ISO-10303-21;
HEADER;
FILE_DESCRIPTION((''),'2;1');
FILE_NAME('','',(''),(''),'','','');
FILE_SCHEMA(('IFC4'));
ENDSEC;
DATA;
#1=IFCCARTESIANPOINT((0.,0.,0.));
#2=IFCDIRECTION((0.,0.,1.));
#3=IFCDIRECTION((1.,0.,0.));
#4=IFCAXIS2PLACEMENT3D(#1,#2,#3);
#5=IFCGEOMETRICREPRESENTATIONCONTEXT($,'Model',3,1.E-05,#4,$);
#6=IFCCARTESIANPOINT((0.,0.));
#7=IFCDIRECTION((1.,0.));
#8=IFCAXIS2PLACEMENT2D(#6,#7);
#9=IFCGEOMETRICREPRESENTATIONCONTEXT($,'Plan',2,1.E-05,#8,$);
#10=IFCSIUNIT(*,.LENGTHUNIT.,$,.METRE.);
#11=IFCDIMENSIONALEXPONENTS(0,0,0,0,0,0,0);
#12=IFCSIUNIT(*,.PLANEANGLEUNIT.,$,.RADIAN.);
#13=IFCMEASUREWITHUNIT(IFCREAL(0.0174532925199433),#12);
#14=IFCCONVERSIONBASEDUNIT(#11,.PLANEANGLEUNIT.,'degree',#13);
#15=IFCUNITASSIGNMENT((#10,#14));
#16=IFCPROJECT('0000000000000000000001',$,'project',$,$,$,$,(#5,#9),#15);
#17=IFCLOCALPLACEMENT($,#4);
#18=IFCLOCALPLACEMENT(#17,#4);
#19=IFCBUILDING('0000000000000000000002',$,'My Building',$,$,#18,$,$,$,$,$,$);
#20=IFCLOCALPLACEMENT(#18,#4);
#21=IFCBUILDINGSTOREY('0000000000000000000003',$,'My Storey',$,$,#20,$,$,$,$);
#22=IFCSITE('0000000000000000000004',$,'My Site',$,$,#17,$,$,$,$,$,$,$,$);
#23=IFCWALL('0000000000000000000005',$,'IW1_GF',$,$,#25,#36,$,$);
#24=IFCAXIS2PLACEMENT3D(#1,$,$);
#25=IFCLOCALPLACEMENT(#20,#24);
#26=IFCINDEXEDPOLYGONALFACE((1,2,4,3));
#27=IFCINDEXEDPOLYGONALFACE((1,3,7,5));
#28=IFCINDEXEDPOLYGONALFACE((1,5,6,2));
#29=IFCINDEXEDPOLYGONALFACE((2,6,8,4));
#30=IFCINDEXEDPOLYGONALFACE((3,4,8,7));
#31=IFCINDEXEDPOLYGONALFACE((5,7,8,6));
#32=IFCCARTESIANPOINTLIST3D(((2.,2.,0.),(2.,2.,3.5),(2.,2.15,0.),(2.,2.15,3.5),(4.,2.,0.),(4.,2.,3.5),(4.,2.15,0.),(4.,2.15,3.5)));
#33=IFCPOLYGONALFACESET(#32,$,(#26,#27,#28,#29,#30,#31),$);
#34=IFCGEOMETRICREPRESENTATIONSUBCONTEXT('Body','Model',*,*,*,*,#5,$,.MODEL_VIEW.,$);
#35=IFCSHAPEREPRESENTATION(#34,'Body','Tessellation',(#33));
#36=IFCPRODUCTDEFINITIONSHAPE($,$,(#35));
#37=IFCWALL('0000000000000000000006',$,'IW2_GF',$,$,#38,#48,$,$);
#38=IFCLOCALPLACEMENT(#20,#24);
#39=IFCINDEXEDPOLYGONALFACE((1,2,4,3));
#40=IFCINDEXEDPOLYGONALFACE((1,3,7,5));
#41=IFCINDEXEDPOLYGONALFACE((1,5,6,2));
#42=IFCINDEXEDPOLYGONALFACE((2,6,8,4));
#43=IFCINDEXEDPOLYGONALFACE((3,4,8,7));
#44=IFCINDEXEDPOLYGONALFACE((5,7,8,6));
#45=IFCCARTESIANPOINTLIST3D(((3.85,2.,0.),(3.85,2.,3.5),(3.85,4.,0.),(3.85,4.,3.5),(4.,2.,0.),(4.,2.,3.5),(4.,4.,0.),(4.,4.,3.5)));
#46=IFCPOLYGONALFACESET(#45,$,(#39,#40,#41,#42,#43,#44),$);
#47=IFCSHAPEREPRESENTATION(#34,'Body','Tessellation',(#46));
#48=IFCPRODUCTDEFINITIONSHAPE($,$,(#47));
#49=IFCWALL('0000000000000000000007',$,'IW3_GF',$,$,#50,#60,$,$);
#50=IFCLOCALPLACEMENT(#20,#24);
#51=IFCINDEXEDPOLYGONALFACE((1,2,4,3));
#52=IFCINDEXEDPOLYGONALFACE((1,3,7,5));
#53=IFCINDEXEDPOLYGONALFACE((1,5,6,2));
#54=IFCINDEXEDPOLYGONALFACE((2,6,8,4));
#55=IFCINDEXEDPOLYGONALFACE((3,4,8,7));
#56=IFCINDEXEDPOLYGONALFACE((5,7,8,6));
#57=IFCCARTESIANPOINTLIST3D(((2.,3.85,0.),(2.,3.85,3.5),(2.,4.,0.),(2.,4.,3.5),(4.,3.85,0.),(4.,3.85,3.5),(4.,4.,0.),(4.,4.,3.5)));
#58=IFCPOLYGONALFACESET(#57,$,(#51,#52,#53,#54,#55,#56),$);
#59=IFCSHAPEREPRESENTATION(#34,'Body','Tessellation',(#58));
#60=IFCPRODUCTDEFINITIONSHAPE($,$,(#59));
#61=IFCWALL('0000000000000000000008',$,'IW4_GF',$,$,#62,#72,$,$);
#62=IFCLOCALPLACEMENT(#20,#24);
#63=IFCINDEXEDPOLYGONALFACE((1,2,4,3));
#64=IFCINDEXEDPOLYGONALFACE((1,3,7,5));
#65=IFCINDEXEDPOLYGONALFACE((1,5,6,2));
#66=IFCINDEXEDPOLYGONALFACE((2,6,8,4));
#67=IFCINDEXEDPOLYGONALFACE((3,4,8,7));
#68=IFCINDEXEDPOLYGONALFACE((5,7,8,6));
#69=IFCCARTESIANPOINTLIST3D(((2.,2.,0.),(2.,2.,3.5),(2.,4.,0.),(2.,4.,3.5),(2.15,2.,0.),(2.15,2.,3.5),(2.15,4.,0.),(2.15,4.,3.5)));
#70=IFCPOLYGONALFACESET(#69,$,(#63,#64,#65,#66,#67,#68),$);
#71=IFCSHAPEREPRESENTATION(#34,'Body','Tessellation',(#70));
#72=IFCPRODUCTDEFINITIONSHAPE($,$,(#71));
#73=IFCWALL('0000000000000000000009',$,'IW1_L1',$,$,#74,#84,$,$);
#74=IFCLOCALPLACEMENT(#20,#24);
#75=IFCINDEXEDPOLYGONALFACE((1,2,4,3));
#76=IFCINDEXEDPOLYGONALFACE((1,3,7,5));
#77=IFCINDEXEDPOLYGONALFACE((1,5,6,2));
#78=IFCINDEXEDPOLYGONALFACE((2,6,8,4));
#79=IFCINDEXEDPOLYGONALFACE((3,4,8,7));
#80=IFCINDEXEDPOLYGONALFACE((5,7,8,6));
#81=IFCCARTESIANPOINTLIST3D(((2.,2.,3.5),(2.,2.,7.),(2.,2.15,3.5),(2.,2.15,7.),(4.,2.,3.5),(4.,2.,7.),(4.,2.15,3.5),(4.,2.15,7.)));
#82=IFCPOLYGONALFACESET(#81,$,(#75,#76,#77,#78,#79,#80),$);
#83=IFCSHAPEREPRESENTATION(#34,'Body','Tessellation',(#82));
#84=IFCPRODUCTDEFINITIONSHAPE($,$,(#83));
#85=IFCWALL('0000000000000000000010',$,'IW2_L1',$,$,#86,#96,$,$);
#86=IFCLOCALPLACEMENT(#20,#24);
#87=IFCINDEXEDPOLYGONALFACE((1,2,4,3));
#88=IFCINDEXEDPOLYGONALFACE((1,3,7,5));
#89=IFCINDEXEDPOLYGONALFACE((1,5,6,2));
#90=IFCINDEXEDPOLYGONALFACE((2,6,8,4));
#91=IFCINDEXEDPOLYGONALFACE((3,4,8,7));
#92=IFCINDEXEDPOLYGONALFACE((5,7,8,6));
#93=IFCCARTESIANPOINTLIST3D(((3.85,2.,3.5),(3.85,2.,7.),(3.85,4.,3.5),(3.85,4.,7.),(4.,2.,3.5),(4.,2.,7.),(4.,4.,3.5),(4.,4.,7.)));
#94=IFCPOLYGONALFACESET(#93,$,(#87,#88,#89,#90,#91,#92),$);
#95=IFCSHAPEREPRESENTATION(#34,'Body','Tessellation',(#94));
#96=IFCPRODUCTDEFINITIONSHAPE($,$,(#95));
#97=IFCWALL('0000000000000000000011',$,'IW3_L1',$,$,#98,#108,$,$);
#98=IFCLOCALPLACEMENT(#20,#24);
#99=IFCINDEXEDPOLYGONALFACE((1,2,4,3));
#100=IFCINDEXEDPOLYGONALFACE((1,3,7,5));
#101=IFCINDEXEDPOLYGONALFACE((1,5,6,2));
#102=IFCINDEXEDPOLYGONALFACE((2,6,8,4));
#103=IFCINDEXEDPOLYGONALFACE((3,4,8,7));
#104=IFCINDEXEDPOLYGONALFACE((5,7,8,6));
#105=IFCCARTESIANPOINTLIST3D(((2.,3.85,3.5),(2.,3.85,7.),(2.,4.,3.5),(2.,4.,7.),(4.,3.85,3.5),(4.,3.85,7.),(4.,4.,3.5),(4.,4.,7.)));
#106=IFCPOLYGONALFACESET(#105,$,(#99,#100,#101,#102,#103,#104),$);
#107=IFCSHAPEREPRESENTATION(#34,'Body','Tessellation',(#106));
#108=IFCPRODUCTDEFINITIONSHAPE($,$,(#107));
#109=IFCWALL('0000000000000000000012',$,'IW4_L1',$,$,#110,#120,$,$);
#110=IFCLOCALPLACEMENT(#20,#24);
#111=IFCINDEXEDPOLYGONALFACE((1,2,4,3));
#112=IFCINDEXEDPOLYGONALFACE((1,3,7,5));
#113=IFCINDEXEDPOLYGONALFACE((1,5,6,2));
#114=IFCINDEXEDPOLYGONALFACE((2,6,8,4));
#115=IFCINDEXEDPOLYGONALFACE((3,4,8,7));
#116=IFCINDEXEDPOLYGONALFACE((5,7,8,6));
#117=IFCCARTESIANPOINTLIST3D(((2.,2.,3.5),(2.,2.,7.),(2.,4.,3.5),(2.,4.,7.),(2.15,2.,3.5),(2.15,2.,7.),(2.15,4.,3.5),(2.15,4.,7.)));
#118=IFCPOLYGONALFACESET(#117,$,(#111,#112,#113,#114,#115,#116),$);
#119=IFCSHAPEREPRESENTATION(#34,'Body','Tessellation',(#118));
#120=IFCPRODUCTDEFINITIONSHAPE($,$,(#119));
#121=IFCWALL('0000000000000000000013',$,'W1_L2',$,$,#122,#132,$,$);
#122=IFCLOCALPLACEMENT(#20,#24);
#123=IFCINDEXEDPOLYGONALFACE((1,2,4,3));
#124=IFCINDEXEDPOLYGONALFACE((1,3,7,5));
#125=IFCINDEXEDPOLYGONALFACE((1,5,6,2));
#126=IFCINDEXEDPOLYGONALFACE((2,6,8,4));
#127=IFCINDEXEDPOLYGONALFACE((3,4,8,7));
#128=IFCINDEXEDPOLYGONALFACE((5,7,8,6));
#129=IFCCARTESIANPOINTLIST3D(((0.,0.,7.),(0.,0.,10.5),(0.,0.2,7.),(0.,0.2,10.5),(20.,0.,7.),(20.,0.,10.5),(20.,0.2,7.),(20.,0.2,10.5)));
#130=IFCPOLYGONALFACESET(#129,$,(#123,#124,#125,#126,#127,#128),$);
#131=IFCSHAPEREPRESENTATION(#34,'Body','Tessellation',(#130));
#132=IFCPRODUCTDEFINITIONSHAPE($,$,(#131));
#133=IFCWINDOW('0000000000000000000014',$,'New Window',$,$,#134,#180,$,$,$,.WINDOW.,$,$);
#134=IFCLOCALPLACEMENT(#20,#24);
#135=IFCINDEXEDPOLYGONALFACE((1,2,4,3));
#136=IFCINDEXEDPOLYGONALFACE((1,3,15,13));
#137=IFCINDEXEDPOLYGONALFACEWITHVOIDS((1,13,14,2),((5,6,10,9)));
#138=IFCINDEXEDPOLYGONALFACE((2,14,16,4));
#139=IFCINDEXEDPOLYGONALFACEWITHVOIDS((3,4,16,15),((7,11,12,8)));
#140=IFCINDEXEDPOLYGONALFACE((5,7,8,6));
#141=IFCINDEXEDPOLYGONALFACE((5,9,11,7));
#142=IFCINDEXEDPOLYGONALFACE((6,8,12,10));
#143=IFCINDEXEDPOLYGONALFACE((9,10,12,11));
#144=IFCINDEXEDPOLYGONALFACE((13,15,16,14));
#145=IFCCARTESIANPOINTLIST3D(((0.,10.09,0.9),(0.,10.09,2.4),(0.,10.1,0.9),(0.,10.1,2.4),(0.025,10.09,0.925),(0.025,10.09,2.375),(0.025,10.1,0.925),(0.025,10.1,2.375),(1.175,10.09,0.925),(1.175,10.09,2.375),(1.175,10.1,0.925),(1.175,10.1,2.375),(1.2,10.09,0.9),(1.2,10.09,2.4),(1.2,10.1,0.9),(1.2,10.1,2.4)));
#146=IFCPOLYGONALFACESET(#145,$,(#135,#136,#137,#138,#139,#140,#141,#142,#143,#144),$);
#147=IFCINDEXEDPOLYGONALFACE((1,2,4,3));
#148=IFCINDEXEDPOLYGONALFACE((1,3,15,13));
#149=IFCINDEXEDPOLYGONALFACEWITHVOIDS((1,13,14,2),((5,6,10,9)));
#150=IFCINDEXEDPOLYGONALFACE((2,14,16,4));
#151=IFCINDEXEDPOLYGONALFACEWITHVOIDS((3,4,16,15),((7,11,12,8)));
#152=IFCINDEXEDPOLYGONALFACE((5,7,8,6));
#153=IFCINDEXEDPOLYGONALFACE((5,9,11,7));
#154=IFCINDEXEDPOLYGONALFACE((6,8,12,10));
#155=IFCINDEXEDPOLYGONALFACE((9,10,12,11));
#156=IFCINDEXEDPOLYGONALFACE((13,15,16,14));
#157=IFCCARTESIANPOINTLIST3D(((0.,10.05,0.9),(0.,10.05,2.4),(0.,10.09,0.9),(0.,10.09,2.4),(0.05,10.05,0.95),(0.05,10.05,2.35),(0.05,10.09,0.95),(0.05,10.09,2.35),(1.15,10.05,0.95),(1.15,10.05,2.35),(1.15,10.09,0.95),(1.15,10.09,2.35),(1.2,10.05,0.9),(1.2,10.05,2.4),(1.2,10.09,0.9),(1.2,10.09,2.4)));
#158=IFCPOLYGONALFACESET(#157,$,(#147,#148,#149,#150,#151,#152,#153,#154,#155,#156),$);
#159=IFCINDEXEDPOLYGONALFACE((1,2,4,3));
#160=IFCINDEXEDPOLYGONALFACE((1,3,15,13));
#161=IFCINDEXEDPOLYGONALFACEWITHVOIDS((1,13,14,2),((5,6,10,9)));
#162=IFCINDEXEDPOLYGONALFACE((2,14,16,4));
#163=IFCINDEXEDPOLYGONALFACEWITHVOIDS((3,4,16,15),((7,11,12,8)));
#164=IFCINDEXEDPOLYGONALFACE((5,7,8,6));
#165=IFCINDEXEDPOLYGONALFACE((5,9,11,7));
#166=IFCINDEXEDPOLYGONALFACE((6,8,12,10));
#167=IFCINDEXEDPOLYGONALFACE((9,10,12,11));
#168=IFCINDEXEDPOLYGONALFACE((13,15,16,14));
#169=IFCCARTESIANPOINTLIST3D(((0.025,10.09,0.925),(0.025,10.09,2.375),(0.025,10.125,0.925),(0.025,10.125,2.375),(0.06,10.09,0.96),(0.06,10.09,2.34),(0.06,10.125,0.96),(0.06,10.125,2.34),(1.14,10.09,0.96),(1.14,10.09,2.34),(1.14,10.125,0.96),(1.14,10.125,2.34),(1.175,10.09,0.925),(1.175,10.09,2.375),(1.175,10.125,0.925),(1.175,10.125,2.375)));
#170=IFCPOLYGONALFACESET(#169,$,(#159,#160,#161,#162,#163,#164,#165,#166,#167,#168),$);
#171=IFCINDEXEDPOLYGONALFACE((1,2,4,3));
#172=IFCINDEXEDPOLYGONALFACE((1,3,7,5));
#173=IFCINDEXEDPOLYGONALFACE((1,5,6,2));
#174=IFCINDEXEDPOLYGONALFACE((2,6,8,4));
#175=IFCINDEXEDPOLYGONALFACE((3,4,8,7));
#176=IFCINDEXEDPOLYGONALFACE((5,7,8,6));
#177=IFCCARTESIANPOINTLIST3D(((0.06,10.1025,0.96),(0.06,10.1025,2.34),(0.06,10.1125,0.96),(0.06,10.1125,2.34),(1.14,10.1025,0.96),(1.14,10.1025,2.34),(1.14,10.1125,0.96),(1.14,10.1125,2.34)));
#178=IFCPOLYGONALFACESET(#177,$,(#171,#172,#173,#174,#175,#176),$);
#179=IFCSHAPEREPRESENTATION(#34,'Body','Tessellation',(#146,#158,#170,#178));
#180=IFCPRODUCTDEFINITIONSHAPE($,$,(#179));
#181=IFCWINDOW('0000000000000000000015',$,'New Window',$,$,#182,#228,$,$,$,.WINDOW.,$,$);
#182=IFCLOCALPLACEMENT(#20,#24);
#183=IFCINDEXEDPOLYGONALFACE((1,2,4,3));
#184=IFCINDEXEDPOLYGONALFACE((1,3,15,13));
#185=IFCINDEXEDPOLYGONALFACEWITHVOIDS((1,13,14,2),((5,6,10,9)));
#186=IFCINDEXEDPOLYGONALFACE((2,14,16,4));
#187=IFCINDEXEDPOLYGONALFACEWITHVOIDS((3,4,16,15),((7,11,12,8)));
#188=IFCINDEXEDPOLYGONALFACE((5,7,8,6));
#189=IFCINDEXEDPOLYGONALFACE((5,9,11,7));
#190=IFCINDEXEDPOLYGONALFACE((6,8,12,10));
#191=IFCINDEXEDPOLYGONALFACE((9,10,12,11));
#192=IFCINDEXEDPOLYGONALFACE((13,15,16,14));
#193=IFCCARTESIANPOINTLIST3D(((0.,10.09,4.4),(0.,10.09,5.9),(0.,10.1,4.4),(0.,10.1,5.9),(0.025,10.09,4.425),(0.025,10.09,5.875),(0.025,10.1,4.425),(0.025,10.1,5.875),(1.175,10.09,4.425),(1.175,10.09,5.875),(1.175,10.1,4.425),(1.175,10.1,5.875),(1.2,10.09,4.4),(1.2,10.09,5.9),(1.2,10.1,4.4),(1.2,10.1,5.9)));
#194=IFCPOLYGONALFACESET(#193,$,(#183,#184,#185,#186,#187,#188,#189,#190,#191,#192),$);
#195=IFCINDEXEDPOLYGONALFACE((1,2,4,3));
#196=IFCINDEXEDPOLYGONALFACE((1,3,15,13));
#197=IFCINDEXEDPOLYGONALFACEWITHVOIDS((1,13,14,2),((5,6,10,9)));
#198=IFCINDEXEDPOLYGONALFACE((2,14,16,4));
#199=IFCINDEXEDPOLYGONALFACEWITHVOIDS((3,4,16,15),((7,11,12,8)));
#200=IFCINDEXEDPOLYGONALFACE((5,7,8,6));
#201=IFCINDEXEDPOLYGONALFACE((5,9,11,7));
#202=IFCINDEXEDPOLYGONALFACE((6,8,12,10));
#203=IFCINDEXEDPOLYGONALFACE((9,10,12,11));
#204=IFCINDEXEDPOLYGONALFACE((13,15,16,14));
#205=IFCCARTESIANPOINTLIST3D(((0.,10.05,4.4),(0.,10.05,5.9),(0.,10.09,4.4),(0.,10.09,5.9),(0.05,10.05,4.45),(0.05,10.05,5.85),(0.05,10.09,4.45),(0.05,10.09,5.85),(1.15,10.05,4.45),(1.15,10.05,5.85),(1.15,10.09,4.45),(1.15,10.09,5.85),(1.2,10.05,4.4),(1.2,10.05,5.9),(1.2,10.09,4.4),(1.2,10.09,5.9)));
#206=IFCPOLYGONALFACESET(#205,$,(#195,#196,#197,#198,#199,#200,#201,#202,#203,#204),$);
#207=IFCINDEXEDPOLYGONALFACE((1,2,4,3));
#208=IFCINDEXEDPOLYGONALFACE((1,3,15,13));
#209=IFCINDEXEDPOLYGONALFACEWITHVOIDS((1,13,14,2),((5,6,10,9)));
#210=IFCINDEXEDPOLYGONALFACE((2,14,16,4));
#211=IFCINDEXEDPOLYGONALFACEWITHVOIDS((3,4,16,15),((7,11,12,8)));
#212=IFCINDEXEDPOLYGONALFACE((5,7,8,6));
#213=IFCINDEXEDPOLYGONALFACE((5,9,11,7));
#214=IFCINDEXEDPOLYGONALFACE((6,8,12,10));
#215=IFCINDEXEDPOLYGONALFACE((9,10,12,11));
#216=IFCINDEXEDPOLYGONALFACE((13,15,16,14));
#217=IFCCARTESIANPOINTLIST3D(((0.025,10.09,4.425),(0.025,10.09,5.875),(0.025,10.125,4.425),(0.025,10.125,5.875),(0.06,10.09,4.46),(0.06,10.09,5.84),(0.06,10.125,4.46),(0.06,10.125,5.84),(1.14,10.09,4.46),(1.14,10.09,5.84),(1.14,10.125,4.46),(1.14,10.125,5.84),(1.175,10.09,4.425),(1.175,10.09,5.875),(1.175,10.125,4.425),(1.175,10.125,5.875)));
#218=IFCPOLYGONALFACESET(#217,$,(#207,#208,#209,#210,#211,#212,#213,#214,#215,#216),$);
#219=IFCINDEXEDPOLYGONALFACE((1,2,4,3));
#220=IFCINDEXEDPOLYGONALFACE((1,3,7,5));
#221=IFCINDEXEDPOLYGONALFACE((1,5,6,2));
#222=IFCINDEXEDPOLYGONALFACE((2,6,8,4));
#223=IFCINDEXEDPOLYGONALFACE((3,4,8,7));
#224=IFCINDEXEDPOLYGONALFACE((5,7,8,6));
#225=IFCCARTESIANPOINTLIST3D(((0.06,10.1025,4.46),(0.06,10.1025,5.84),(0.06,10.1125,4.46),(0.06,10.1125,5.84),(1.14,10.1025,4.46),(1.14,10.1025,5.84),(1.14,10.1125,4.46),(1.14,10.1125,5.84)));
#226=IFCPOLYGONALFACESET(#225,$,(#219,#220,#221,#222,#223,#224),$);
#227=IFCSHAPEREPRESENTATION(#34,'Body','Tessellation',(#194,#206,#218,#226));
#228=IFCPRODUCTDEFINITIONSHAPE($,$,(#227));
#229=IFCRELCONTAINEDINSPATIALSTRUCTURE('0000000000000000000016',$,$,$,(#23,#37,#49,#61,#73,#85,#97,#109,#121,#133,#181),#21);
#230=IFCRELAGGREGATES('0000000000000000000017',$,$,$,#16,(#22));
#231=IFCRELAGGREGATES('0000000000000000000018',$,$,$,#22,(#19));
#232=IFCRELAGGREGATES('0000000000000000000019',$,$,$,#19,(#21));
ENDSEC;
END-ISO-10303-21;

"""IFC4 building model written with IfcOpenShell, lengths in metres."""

from ifc_helpers import new_model, entity, si_unit, converted_unit, frame, origin_with_axes, origin_2d_with_axis, place, context, subcontext, project, spatial, line, indexed_curve, outline, extrude, element, save


model = new_model("IFC4")

# Units and contexts
model_context = context("Model", 3, precision=1e-05, world=origin_with_axes())
plan_context = context("Plan", 2, precision=1e-05, world=origin_2d_with_axis())
body_context = subcontext(model_context, "Body", "Model", "MODEL_VIEW")
ifc_project = project(units=[si_unit("LENGTHUNIT", "METRE"), converted_unit("PLANEANGLEUNIT", "degree", entity("IfcReal", 0.0174532925199433), si_unit("PLANEANGLEUNIT", "RADIAN"), dimensions=[0, 0, 0, 0, 0, 0, 0])], contexts=[model_context, plan_context])

# Site, building, storey
site_placement = place(None, origin_with_axes())
site = spatial("IfcSite", under=ifc_project, at=site_placement, Name="My Site")
building_placement = place(site_placement, origin_with_axes())
building = spatial("IfcBuilding", under=site, at=building_placement, Name="My Building")
storey_placement = place(building_placement, origin_with_axes())
storey = spatial("IfcBuildingStorey", under=building, at=storey_placement, Name="My Storey")

# Walls
for number, where, z_axis, x_axis, name in (
    (1, (2.0, 2.0, 0.0), (0.0, 0.0, 1.0), (1.0, 0.0, 0.0), "IW1_GF"),
    (2, (4.0, 2.0, 0.0), (0.0, 0.0, 1.0), (0.0, 1.0, 0.0), "IW2_GF"),
    (3, (4.0, 4.0, 0.0), (0.0, 0.0, 1.0), (-1.0, 0.0, 0.0), "IW3_GF"),
    (4, (2.0, 4.0, 0.0), (0.0, 0.0, 1.0), (0.0, -1.0, 0.0), "IW4_GF"),
    (5, (2.0, 2.0, 3.5), (0.0, 0.0, 1.0), (1.0, 0.0, 0.0), "IW1_L1"),
    (6, (4.0, 2.0, 3.5), (0.0, 0.0, 1.0), (0.0, 1.0, 0.0), "IW2_L1"),
    (7, (4.0, 4.0, 3.5), (0.0, 0.0, 1.0), (-1.0, 0.0, 0.0), "IW3_L1"),
    (8, (2.0, 4.0, 3.5), (0.0, 0.0, 1.0), (0.0, -1.0, 0.0), "IW4_L1"),
):
    element("IfcWall", number, at=place(storey_placement, frame(where, z_axis=z_axis, x_axis=x_axis)), inside=storey, Name=name, context=body_context, shape_type="SweptSolid", body=[
        extrude(outline(indexed_curve([(0.0, 0.0), (0.0, 0.15), (2.0, 0.15), (2.0, 0.0), (0.0, 0.0)], self_intersect=False)), origin_with_axes(), (0.0, 0.0, 1.0), 3.5),
    ])
wall_1_placement = place(storey_placement, frame((0.0, 0.0, 7.0), z_axis=(0.0, 0.0, 1.0), x_axis=(1.0, 0.0, 0.0)))
element("IfcWall", 9, at=wall_1_placement, inside=storey, Name="W1_L2", context=body_context, shape_type="SweptSolid", body=[
    extrude(outline(indexed_curve([(0.0, 0.0), (0.0, 0.2), (20.0, 0.2), (20.0, 0.0), (0.0, 0.0)], self_intersect=False)), origin_with_axes(), (0.0, 0.0, 1.0), 3.5),
])

# Windows
for number, where, z_axis, x_axis, name in (
    (10, (0.0, 10.0, 0.9), (0.0, 0.0, 1.0), (1.0, 0.0, 0.0), "New Window"),
    (11, (0.0, 10.0, 4.4), (0.0, 0.0, 1.0), (1.0, 0.0, 0.0), "New Window"),
):
    element("IfcWindow", number, at=place(storey_placement, frame(where, z_axis=z_axis, x_axis=x_axis)), inside=storey, Name=name, PredefinedType="WINDOW", context=body_context, shape_type="SweptSolid", body=[
        extrude(outline(indexed_curve([(0.0, 0.0), (1.2, 0.0), (1.2, 1.5), (0.0, 1.5)], segments=[line(1, 2, 3, 4, 1)]), holes=[indexed_curve([(0.025, 0.025), (1.175, 0.025), (1.175, 1.475), (0.025, 1.475)], segments=[line(1, 2, 3, 4, 1)])]), frame((0.0, 0.09, 0.0), z_axis=(0.0, -1.0, 0.0), x_axis=(1.0, 0.0, 0.0)), (0.0, 0.0, -1.0), 0.01),
        extrude(outline(indexed_curve([(0.0, 0.0), (1.2, 0.0), (1.2, 1.5), (0.0, 1.5)], segments=[line(1, 2, 3, 4, 1)]), holes=[indexed_curve([(0.05, 0.05), (1.15, 0.05), (1.15, 1.45), (0.05, 1.45)], segments=[line(1, 2, 3, 4, 1)])]), frame((0.0, 0.05, 0.0), z_axis=(0.0, -1.0, 0.0), x_axis=(1.0, 0.0, 0.0)), (0.0, 0.0, -1.0), 0.04),
        extrude(outline(indexed_curve([(0.0, 0.0), (1.15, 0.0), (1.15, 1.45), (0.0, 1.45)], segments=[line(1, 2, 3, 4, 1)]), holes=[indexed_curve([(0.035, 0.035), (1.115, 0.035), (1.115, 1.415), (0.035, 1.415)], segments=[line(1, 2, 3, 4, 1)])]), frame((0.025, 0.09, 0.025), z_axis=(0.0, -1.0, 0.0), x_axis=(1.0, 0.0, 0.0)), (0.0, 0.0, -1.0), 0.035),
        extrude(outline(indexed_curve([(0.035, 0.035), (1.115, 0.035), (1.115, 1.415), (0.035, 1.415)], segments=[line(1, 2, 3, 4, 1)])), frame((0.025, 0.1025, 0.025), z_axis=(0.0, -1.0, 0.0), x_axis=(1.0, 0.0, 0.0)), (0.0, 0.0, -1.0), 0.01),
    ])

save(model, "model.ifc")
